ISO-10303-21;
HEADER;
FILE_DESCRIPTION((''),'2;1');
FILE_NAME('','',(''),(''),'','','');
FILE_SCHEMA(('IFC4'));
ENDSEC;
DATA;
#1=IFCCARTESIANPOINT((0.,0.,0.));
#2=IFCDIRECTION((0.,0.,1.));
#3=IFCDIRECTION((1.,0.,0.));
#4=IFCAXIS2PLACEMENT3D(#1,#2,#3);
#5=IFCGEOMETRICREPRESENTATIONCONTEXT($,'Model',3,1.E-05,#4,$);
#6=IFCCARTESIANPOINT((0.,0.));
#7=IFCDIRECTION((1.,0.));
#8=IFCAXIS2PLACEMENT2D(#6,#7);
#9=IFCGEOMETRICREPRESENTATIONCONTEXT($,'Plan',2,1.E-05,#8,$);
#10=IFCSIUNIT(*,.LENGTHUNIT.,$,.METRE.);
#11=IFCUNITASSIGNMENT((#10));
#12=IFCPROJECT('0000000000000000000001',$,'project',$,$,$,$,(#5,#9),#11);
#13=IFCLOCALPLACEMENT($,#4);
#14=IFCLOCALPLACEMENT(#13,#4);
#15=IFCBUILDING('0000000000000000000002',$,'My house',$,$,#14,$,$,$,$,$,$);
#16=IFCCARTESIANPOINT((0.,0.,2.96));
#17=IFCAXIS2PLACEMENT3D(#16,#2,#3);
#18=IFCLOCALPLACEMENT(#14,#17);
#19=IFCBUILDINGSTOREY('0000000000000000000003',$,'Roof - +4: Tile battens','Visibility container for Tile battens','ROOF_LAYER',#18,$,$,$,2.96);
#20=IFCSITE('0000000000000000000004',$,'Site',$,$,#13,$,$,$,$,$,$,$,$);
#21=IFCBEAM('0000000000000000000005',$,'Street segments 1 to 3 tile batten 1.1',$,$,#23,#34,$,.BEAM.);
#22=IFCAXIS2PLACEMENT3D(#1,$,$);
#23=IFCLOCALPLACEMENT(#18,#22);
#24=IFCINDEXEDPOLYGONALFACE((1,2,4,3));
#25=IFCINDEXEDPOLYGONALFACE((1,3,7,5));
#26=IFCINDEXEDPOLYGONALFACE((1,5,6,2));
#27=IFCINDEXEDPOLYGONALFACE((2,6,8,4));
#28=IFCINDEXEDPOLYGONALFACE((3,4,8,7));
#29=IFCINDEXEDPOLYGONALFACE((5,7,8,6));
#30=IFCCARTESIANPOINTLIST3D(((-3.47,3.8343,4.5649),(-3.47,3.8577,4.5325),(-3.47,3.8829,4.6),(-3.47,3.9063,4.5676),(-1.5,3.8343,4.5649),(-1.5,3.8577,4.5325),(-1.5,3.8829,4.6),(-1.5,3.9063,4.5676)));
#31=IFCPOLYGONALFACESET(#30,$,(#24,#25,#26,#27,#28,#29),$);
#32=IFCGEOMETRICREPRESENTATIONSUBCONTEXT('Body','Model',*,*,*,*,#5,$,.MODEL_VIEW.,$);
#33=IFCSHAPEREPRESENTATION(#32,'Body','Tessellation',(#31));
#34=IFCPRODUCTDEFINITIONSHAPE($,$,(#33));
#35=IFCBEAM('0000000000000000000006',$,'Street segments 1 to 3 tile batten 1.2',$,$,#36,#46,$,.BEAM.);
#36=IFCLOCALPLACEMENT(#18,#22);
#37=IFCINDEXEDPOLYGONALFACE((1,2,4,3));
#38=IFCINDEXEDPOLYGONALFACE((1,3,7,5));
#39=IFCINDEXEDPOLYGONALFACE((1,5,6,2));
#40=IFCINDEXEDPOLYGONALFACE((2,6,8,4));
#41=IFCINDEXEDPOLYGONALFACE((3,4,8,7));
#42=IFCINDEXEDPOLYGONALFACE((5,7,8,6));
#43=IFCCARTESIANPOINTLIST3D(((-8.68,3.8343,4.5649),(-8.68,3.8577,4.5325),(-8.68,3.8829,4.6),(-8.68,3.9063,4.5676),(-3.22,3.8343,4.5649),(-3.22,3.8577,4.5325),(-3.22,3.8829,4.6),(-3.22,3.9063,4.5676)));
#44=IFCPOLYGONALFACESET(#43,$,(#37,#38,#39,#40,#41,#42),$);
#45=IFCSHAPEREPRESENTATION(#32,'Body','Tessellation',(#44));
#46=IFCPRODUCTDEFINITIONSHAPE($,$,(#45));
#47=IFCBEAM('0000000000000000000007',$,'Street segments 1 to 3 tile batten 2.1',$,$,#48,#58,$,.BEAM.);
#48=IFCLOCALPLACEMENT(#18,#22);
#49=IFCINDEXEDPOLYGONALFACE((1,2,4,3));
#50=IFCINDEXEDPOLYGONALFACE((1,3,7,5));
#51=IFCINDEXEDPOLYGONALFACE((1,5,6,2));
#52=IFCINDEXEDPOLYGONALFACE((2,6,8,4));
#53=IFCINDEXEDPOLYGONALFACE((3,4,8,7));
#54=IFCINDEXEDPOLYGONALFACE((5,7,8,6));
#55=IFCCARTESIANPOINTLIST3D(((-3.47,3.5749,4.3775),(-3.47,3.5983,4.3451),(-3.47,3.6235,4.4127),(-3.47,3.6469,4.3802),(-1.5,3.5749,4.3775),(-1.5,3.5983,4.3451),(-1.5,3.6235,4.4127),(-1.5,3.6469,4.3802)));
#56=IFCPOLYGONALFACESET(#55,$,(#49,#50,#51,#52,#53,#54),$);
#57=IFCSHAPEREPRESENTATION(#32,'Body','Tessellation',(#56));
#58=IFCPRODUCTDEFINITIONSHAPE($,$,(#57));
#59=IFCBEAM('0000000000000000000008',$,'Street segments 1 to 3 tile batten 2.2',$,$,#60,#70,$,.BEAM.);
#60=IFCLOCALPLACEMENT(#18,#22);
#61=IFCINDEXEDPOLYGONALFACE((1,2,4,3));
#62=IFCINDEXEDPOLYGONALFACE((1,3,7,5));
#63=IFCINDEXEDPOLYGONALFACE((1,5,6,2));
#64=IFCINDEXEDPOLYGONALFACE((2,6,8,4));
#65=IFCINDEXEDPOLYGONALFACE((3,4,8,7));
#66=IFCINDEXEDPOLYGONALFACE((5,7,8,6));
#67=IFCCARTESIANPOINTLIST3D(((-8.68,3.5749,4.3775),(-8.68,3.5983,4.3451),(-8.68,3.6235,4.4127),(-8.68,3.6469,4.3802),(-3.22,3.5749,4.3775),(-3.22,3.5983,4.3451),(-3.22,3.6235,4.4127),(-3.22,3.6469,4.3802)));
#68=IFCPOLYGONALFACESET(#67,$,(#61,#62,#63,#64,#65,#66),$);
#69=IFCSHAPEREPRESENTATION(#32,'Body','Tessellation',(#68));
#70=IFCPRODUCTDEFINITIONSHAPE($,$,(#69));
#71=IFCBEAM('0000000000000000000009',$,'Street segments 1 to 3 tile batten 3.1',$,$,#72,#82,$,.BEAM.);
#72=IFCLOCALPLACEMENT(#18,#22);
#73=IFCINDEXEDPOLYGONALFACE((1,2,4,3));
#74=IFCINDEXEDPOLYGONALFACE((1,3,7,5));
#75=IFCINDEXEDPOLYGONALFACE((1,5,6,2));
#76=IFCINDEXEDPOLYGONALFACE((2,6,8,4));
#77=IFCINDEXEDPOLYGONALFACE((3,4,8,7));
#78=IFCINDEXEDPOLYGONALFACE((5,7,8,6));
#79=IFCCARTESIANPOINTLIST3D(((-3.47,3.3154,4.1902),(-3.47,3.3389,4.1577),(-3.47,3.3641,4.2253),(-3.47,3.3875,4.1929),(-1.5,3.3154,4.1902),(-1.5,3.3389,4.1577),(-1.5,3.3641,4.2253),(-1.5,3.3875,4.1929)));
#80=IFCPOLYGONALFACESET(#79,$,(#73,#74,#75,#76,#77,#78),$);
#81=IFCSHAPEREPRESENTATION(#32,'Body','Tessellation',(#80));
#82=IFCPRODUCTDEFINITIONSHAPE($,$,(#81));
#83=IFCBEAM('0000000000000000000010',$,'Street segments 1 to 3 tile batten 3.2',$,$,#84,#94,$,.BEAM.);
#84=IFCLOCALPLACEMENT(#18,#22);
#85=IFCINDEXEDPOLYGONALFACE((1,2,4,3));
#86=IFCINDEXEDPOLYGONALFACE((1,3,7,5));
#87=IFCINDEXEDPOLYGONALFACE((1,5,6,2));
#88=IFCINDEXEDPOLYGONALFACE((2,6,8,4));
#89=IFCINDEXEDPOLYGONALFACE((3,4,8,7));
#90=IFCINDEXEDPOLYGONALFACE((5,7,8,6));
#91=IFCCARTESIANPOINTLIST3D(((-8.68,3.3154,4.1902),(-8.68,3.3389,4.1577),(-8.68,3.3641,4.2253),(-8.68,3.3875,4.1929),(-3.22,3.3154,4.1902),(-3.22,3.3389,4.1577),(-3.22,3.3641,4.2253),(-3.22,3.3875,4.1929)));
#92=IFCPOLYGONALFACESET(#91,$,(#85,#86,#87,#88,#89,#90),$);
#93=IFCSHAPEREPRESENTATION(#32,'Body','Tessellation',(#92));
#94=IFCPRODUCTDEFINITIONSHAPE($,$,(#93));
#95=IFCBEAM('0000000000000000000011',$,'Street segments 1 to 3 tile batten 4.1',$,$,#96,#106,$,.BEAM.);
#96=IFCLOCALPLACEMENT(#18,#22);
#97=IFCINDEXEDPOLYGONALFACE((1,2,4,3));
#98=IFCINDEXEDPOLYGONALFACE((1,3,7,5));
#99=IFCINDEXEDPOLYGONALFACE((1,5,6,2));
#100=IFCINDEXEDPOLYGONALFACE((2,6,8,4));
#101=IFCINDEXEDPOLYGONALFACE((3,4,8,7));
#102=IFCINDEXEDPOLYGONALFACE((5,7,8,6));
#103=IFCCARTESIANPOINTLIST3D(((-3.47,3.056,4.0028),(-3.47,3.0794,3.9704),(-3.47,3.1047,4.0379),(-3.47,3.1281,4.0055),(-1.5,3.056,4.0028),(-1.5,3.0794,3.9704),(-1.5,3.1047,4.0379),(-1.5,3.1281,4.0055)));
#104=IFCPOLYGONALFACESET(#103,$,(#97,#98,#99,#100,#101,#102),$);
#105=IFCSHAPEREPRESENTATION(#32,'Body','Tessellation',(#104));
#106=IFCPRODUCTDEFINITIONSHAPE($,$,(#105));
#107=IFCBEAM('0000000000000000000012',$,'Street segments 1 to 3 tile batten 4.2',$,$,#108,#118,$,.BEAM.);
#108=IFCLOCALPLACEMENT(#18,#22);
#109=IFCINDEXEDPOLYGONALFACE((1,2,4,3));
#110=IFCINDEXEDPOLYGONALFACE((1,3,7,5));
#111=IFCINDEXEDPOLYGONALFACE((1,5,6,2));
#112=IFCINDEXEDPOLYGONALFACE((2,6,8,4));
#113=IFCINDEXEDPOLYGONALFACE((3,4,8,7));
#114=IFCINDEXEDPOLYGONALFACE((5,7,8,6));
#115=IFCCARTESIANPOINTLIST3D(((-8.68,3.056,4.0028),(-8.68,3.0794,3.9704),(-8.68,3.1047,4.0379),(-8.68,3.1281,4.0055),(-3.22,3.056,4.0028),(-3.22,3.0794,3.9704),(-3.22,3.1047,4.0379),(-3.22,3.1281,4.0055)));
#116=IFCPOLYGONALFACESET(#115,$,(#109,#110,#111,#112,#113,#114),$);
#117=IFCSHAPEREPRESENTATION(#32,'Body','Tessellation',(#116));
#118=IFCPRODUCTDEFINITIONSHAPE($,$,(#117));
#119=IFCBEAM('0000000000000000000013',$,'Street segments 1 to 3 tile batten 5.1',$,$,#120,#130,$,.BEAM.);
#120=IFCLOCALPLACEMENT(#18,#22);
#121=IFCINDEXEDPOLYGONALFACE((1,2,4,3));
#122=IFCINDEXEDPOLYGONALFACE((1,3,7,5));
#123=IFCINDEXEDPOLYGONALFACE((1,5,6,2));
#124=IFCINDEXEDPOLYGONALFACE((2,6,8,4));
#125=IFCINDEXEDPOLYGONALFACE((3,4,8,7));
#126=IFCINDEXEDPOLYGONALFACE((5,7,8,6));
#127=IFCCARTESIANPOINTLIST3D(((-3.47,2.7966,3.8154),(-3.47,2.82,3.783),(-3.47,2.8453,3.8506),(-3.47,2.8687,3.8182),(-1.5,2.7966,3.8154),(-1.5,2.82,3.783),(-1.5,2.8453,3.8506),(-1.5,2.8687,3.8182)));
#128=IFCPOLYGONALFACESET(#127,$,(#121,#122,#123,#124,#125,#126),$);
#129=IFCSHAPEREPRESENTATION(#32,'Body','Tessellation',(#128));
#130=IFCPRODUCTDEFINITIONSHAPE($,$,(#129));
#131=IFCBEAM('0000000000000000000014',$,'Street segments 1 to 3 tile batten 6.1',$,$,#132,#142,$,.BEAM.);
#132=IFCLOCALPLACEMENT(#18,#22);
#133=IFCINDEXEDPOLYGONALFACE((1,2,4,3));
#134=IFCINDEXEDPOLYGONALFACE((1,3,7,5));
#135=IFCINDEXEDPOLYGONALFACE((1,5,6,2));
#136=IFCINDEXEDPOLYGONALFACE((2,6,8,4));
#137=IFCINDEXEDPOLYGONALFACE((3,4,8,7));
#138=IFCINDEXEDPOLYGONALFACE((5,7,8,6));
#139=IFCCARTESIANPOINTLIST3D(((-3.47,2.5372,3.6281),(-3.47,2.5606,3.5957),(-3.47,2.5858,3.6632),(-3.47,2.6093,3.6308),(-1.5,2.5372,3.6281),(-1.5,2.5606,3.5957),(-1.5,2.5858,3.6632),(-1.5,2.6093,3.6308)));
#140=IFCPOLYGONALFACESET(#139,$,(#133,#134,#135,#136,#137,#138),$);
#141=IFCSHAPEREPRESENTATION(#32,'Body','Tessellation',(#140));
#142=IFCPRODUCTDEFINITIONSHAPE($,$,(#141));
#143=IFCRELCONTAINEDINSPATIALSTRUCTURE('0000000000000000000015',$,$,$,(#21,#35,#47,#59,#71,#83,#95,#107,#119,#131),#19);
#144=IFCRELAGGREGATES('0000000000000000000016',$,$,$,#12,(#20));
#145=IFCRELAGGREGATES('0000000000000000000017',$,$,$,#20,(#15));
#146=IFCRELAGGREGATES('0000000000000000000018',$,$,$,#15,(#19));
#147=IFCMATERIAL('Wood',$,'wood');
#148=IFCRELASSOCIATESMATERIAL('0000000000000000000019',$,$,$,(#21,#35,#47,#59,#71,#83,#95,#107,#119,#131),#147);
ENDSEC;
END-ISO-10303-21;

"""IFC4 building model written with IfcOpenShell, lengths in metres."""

from ifc_helpers import new_model, si_unit, frame, origin_with_axes, origin_2d_with_axis, place, context, subcontext, project, spatial, rectangle, extrude, clip, halfspace, source, transform, mapped, material, element, save


model = new_model("IFC4")

# Units and contexts
model_context = context("Model", 3, precision=1e-05, world=origin_with_axes())
plan_context = context("Plan", 2, precision=1e-05, world=origin_2d_with_axis())
body_context = subcontext(model_context, "Body", "Model", "MODEL_VIEW")
ifc_project = project(units=[si_unit("LENGTHUNIT", "METRE")], contexts=[model_context, plan_context])

# Site, building, storey
site_placement = place(None, origin_with_axes())
site = spatial("IfcSite", under=ifc_project, at=site_placement, Name="Site")
building_placement = place(site_placement, origin_with_axes())
building = spatial("IfcBuilding", under=site, at=building_placement, Name="My house")
storey_placement = place(building_placement, frame((0.0, 0.0, 2.96), z_axis=(0.0, 0.0, 1.0), x_axis=(1.0, 0.0, 0.0)))
storey = spatial("IfcBuildingStorey", under=building, at=storey_placement, Name="Roof - +4: Tile battens", Description="Visibility container for Tile battens", ObjectType="ROOF_LAYER", Elevation=2.96)

# Beams
ifc_material = material(Name="Wood", Category="wood")
shared_shape_1 = source(origin_with_axes(), body_context, "Body", "Clipping", [
    clip(clip(extrude(rectangle(XDim=0.06, YDim=0.04), frame((0.0, 0.0, 0.0), z_axis=(1.0, 0.0, 0.0), x_axis=(0.0, 1.0, 0.0)), (0.0, 0.0, 1.0), 1.97), halfspace(frame((-1.5, -4.3016, -6.1772), z_axis=(0.0, 0.810664, -0.585512), x_axis=(1.0, 0.0, 0.0)), False)), halfspace(frame((-1.5, -8.1522, -3.396), z_axis=(0.0, -0.810664, 0.585512), x_axis=(-1.0, 0.0, 0.0)), False)),
])
beam_1_placement = place(storey_placement, frame((-1.5, 3.8703, 4.5663), z_axis=(0.0, -0.585512, 0.810664), x_axis=(1.0, 0.0, 0.0)))
element("IfcBeam", 1, at=beam_1_placement, inside=storey, material=ifc_material, Name="Street segments 1 to 3 tile batten 1.1", PredefinedType="BEAM", context=body_context, shape_type="MappedRepresentation", body=[
    mapped(shared_shape_1, transform((0.0, 0.0, 0.0), x_axis=(-1.0, 0.0, 0.0), y_axis=(0.0, 1.0, 0.0), z_axis=(0.0, 0.0, 1.0), scale=1.0)),
])
shared_shape_2 = source(origin_with_axes(), body_context, "Body", "Clipping", [
    clip(clip(extrude(rectangle(XDim=0.06, YDim=0.04), frame((0.0, 0.0, 0.0), z_axis=(1.0, 0.0, 0.0), x_axis=(0.0, 1.0, 0.0)), (0.0, 0.0, 1.0), 5.46), halfspace(frame((-3.22, -4.3016, -6.1772), z_axis=(0.0, 0.810664, -0.585512), x_axis=(1.0, 0.0, 0.0)), False)), halfspace(frame((-3.22, -8.1522, -3.396), z_axis=(0.0, -0.810664, 0.585512), x_axis=(-1.0, 0.0, 0.0)), False)),
])
beam_2_placement = place(storey_placement, frame((-3.22, 3.8703, 4.5663), z_axis=(0.0, -0.585512, 0.810664), x_axis=(1.0, 0.0, 0.0)))
element("IfcBeam", 2, at=beam_2_placement, inside=storey, material=ifc_material, Name="Street segments 1 to 3 tile batten 1.2", PredefinedType="BEAM", context=body_context, shape_type="MappedRepresentation", body=[
    mapped(shared_shape_2, transform((0.0, 0.0, 0.0), x_axis=(-1.0, 0.0, 0.0), y_axis=(0.0, 1.0, 0.0), z_axis=(0.0, 0.0, 1.0), scale=1.0)),
])
shared_shape_3 = source(origin_with_axes(), body_context, "Body", "Clipping", [
    clip(clip(extrude(rectangle(XDim=0.06, YDim=0.04), frame((0.0, 0.0, 0.0), z_axis=(1.0, 0.0, 0.0), x_axis=(0.0, 1.0, 0.0)), (0.0, 0.0, 1.0), 1.97), halfspace(frame((-1.5, -3.9816, -6.1772), z_axis=(0.0, 0.810664, -0.585512), x_axis=(1.0, 0.0, 0.0)), False)), halfspace(frame((-1.5, -7.8322, -3.396), z_axis=(0.0, -0.810664, 0.585512), x_axis=(-1.0, 0.0, 0.0)), False)),
])
beam_3_placement = place(storey_placement, frame((-1.5, 3.6109, 4.3789), z_axis=(0.0, -0.585512, 0.810664), x_axis=(1.0, 0.0, 0.0)))
element("IfcBeam", 3, at=beam_3_placement, inside=storey, material=ifc_material, Name="Street segments 1 to 3 tile batten 2.1", PredefinedType="BEAM", context=body_context, shape_type="MappedRepresentation", body=[
    mapped(shared_shape_3, transform((0.0, 0.0, 0.0), x_axis=(-1.0, 0.0, 0.0), y_axis=(0.0, 1.0, 0.0), z_axis=(0.0, 0.0, 1.0), scale=1.0)),
])
shared_shape_4 = source(origin_with_axes(), body_context, "Body", "Clipping", [
    clip(clip(extrude(rectangle(XDim=0.06, YDim=0.04), frame((0.0, 0.0, 0.0), z_axis=(1.0, 0.0, 0.0), x_axis=(0.0, 1.0, 0.0)), (0.0, 0.0, 1.0), 5.46), halfspace(frame((-3.22, -3.9816, -6.1772), z_axis=(0.0, 0.810664, -0.585512), x_axis=(1.0, 0.0, 0.0)), False)), halfspace(frame((-3.22, -7.8322, -3.396), z_axis=(0.0, -0.810664, 0.585512), x_axis=(-1.0, 0.0, 0.0)), False)),
])
beam_4_placement = place(storey_placement, frame((-3.22, 3.6109, 4.3789), z_axis=(0.0, -0.585512, 0.810664), x_axis=(1.0, 0.0, 0.0)))
element("IfcBeam", 4, at=beam_4_placement, inside=storey, material=ifc_material, Name="Street segments 1 to 3 tile batten 2.2", PredefinedType="BEAM", context=body_context, shape_type="MappedRepresentation", body=[
    mapped(shared_shape_4, transform((0.0, 0.0, 0.0), x_axis=(-1.0, 0.0, 0.0), y_axis=(0.0, 1.0, 0.0), z_axis=(0.0, 0.0, 1.0), scale=1.0)),
])
shared_shape_5 = source(origin_with_axes(), body_context, "Body", "Clipping", [
    clip(clip(extrude(rectangle(XDim=0.06, YDim=0.04), frame((0.0, 0.0, 0.0), z_axis=(1.0, 0.0, 0.0), x_axis=(0.0, 1.0, 0.0)), (0.0, 0.0, 1.0), 1.97), halfspace(frame((-1.5, -3.6616, -6.1772), z_axis=(0.0, 0.810664, -0.585512), x_axis=(1.0, 0.0, 0.0)), False)), halfspace(frame((-1.5, -7.5122, -3.396), z_axis=(0.0, -0.810664, 0.585512), x_axis=(-1.0, 0.0, 0.0)), False)),
])
beam_5_placement = place(storey_placement, frame((-1.5, 3.3515, 4.1915), z_axis=(0.0, -0.585512, 0.810664), x_axis=(1.0, 0.0, 0.0)))
element("IfcBeam", 5, at=beam_5_placement, inside=storey, material=ifc_material, Name="Street segments 1 to 3 tile batten 3.1", PredefinedType="BEAM", context=body_context, shape_type="MappedRepresentation", body=[
    mapped(shared_shape_5, transform((0.0, 0.0, 0.0), x_axis=(-1.0, 0.0, 0.0), y_axis=(0.0, 1.0, 0.0), z_axis=(0.0, 0.0, 1.0), scale=1.0)),
])
shared_shape_6 = source(origin_with_axes(), body_context, "Body", "Clipping", [
    clip(clip(extrude(rectangle(XDim=0.06, YDim=0.04), frame((0.0, 0.0, 0.0), z_axis=(1.0, 0.0, 0.0), x_axis=(0.0, 1.0, 0.0)), (0.0, 0.0, 1.0), 5.46), halfspace(frame((-3.22, -3.6616, -6.1772), z_axis=(0.0, 0.810664, -0.585512), x_axis=(1.0, 0.0, 0.0)), False)), halfspace(frame((-3.22, -7.5122, -3.396), z_axis=(0.0, -0.810664, 0.585512), x_axis=(-1.0, 0.0, 0.0)), False)),
])
beam_6_placement = place(storey_placement, frame((-3.22, 3.3515, 4.1915), z_axis=(0.0, -0.585512, 0.810664), x_axis=(1.0, 0.0, 0.0)))
element("IfcBeam", 6, at=beam_6_placement, inside=storey, material=ifc_material, Name="Street segments 1 to 3 tile batten 3.2", PredefinedType="BEAM", context=body_context, shape_type="MappedRepresentation", body=[
    mapped(shared_shape_6, transform((0.0, 0.0, 0.0), x_axis=(-1.0, 0.0, 0.0), y_axis=(0.0, 1.0, 0.0), z_axis=(0.0, 0.0, 1.0), scale=1.0)),
])
shared_shape_7 = source(origin_with_axes(), body_context, "Body", "Clipping", [
    clip(clip(extrude(rectangle(XDim=0.06, YDim=0.04), frame((0.0, 0.0, 0.0), z_axis=(1.0, 0.0, 0.0), x_axis=(0.0, 1.0, 0.0)), (0.0, 0.0, 1.0), 1.97), halfspace(frame((-1.5, -3.3416, -6.1772), z_axis=(0.0, 0.810664, -0.585512), x_axis=(1.0, 0.0, 0.0)), False)), halfspace(frame((-1.5, -7.1922, -3.396), z_axis=(0.0, -0.810664, 0.585512), x_axis=(-1.0, 0.0, 0.0)), False)),
])
beam_7_placement = place(storey_placement, frame((-1.5, 3.0921, 4.0042), z_axis=(0.0, -0.585512, 0.810664), x_axis=(1.0, 0.0, 0.0)))
element("IfcBeam", 7, at=beam_7_placement, inside=storey, material=ifc_material, Name="Street segments 1 to 3 tile batten 4.1", PredefinedType="BEAM", context=body_context, shape_type="MappedRepresentation", body=[
    mapped(shared_shape_7, transform((0.0, 0.0, 0.0), x_axis=(-1.0, 0.0, 0.0), y_axis=(0.0, 1.0, 0.0), z_axis=(0.0, 0.0, 1.0), scale=1.0)),
])
shared_shape_8 = source(origin_with_axes(), body_context, "Body", "Clipping", [
    clip(clip(extrude(rectangle(XDim=0.06, YDim=0.04), frame((0.0, 0.0, 0.0), z_axis=(1.0, 0.0, 0.0), x_axis=(0.0, 1.0, 0.0)), (0.0, 0.0, 1.0), 5.46), halfspace(frame((-3.22, -3.3416, -6.1772), z_axis=(0.0, 0.810664, -0.585512), x_axis=(1.0, 0.0, 0.0)), False)), halfspace(frame((-3.22, -7.1922, -3.396), z_axis=(0.0, -0.810664, 0.585512), x_axis=(-1.0, 0.0, 0.0)), False)),
])
beam_8_placement = place(storey_placement, frame((-3.22, 3.0921, 4.0042), z_axis=(0.0, -0.585512, 0.810664), x_axis=(1.0, 0.0, 0.0)))
element("IfcBeam", 8, at=beam_8_placement, inside=storey, material=ifc_material, Name="Street segments 1 to 3 tile batten 4.2", PredefinedType="BEAM", context=body_context, shape_type="MappedRepresentation", body=[
    mapped(shared_shape_8, transform((0.0, 0.0, 0.0), x_axis=(-1.0, 0.0, 0.0), y_axis=(0.0, 1.0, 0.0), z_axis=(0.0, 0.0, 1.0), scale=1.0)),
])
shared_shape_9 = source(origin_with_axes(), body_context, "Body", "Clipping", [
    clip(clip(extrude(rectangle(XDim=0.06, YDim=0.04), frame((0.0, 0.0, 0.0), z_axis=(1.0, 0.0, 0.0), x_axis=(0.0, 1.0, 0.0)), (0.0, 0.0, 1.0), 1.97), halfspace(frame((-1.5, -3.0216, -6.1772), z_axis=(0.0, 0.810664, -0.585512), x_axis=(1.0, 0.0, 0.0)), False)), halfspace(frame((-1.5, -6.8722, -3.396), z_axis=(0.0, -0.810664, 0.585512), x_axis=(-1.0, 0.0, 0.0)), False)),
])
beam_9_placement = place(storey_placement, frame((-1.5, 2.8326, 3.8168), z_axis=(0.0, -0.585512, 0.810664), x_axis=(1.0, 0.0, 0.0)))
element("IfcBeam", 9, at=beam_9_placement, inside=storey, material=ifc_material, Name="Street segments 1 to 3 tile batten 5.1", PredefinedType="BEAM", context=body_context, shape_type="MappedRepresentation", body=[
    mapped(shared_shape_9, transform((0.0, 0.0, 0.0), x_axis=(-1.0, 0.0, 0.0), y_axis=(0.0, 1.0, 0.0), z_axis=(0.0, 0.0, 1.0), scale=1.0)),
])
shared_shape_10 = source(origin_with_axes(), body_context, "Body", "Clipping", [
    clip(clip(extrude(rectangle(XDim=0.06, YDim=0.04), frame((0.0, 0.0, 0.0), z_axis=(1.0, 0.0, 0.0), x_axis=(0.0, 1.0, 0.0)), (0.0, 0.0, 1.0), 1.97), halfspace(frame((-1.5, -2.7016, -6.1772), z_axis=(0.0, 0.810664, -0.585512), x_axis=(1.0, 0.0, 0.0)), False)), halfspace(frame((-1.5, -6.5522, -3.396), z_axis=(0.0, -0.810664, 0.585512), x_axis=(-1.0, 0.0, 0.0)), False)),
])
beam_10_placement = place(storey_placement, frame((-1.5, 2.5732, 3.6294), z_axis=(0.0, -0.585512, 0.810664), x_axis=(1.0, 0.0, 0.0)))
element("IfcBeam", 10, at=beam_10_placement, inside=storey, material=ifc_material, Name="Street segments 1 to 3 tile batten 6.1", PredefinedType="BEAM", context=body_context, shape_type="MappedRepresentation", body=[
    mapped(shared_shape_10, transform((0.0, 0.0, 0.0), x_axis=(-1.0, 0.0, 0.0), y_axis=(0.0, 1.0, 0.0), z_axis=(0.0, 0.0, 1.0), scale=1.0)),
])

save(model, "model.ifc")
